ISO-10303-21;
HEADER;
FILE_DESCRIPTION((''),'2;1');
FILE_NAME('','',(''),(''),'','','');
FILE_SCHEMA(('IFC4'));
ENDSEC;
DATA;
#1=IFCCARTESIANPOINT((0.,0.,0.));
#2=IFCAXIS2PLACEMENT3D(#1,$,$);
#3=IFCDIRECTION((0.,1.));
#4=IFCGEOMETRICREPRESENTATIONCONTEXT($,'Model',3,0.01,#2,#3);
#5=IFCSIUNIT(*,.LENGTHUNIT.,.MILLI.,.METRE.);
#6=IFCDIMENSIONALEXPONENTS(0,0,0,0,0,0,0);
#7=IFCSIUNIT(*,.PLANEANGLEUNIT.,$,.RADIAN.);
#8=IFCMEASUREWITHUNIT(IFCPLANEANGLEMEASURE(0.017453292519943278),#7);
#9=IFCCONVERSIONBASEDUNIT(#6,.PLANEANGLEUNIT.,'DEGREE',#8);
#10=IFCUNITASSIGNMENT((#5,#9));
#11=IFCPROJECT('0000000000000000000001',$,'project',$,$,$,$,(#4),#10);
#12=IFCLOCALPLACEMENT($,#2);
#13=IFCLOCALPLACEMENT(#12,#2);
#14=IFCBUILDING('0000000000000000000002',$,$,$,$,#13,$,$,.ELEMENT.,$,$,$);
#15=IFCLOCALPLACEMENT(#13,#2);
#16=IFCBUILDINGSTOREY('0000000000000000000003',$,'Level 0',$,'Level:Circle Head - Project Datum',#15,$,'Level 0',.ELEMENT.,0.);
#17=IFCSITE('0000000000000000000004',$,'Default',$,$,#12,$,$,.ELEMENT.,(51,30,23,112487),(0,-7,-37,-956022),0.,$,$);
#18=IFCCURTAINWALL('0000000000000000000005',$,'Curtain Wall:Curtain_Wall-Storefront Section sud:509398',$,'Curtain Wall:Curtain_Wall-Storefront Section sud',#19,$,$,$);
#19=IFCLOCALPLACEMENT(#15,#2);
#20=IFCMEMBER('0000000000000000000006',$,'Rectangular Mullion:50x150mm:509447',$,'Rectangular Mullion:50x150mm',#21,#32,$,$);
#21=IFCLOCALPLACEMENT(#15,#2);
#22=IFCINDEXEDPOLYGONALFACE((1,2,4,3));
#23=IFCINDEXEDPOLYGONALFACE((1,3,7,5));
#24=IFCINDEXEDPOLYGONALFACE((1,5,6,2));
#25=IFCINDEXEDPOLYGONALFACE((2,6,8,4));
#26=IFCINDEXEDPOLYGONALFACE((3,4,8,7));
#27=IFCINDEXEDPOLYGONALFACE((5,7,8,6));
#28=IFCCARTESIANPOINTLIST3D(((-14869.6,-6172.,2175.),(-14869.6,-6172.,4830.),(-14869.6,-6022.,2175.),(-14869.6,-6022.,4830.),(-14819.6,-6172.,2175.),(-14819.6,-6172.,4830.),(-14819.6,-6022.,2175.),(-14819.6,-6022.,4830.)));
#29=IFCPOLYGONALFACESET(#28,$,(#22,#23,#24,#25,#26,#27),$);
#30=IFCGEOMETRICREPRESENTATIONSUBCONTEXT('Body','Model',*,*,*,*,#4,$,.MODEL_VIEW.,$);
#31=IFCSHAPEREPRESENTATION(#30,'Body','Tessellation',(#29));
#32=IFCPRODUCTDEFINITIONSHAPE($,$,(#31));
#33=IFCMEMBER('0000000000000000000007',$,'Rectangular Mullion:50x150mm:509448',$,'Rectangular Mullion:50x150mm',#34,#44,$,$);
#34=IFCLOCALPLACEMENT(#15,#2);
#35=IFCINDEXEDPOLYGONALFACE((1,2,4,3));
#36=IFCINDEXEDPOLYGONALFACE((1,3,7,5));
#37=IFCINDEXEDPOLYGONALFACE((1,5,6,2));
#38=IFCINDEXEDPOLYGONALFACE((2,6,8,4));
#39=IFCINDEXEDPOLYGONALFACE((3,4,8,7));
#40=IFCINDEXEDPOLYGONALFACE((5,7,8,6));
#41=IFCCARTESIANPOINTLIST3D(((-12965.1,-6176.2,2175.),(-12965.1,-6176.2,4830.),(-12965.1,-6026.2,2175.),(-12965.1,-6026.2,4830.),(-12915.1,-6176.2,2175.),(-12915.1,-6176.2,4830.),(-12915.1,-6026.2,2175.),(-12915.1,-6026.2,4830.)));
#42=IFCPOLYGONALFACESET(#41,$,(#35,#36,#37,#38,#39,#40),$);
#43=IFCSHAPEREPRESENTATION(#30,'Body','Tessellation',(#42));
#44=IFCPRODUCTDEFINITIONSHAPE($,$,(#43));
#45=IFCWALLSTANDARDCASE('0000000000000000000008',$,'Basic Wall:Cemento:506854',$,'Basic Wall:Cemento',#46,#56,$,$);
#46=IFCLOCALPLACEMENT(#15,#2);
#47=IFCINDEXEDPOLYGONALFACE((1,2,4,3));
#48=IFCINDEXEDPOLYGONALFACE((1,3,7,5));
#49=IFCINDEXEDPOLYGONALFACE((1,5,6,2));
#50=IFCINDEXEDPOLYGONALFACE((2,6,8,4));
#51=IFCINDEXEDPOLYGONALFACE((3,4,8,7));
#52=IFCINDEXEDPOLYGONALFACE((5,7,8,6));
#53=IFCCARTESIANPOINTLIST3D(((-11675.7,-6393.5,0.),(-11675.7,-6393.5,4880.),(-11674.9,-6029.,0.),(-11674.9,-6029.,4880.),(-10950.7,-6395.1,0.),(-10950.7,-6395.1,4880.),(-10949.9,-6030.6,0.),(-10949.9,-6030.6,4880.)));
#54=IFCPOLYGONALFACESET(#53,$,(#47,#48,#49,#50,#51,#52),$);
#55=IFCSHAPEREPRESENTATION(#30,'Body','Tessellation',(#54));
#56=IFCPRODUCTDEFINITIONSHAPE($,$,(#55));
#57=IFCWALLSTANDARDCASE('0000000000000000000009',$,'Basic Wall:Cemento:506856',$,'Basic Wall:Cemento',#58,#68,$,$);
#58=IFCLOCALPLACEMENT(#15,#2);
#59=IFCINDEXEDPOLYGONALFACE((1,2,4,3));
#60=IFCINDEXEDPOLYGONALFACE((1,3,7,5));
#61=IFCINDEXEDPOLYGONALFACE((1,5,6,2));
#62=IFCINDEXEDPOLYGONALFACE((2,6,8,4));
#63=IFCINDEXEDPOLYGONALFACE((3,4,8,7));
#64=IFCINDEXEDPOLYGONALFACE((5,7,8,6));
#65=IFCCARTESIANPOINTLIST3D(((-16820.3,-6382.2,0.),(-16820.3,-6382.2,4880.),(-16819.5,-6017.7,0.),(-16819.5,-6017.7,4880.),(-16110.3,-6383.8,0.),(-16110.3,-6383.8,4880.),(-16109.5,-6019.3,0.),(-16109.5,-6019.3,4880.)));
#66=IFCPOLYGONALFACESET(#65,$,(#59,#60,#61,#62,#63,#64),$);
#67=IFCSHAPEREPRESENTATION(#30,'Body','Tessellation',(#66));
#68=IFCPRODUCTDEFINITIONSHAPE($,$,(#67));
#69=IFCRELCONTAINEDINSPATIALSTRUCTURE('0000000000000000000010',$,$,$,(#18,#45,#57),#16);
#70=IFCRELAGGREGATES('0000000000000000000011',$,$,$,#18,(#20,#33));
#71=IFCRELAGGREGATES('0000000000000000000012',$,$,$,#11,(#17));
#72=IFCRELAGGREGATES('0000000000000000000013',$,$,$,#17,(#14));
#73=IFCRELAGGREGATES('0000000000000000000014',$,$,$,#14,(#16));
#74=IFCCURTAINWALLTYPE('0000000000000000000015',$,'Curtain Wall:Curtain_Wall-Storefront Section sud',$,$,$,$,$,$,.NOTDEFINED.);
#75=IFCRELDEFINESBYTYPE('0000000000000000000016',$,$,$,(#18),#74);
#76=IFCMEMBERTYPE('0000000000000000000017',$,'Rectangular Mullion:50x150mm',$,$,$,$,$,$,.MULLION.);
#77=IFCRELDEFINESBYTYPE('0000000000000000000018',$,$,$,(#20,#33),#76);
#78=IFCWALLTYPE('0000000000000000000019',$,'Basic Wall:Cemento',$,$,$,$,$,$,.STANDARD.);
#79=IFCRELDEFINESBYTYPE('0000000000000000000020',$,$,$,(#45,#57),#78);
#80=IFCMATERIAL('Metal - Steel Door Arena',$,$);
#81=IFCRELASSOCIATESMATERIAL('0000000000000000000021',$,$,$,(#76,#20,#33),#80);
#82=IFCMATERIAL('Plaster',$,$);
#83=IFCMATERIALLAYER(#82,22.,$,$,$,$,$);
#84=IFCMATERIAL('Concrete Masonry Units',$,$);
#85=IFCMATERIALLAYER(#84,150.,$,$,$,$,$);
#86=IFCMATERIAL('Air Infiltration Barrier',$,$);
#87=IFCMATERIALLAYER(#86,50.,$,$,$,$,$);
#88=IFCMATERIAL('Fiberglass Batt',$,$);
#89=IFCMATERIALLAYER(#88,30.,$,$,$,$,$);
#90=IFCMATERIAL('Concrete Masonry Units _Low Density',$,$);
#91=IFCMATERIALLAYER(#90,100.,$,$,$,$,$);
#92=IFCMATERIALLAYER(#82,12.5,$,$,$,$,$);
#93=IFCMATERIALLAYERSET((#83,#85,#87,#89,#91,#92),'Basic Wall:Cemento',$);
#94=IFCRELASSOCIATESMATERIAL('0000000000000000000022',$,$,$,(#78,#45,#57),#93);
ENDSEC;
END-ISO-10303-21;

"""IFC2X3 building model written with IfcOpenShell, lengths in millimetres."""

from ifc_helpers import new_model, entity, si_unit, converted_unit, direction, frame, frame_2d, origin, origin_2d_with_axis, place, context, subcontext, project, spatial, rectangle, extrude, source, transform, mapped, material, layer, layer_set, layer_usage, type_object, type_shapes, element, aggregate, save


model = new_model("IFC2X3")

# Units and contexts
model_context = context("Model", 3, precision=0.01, world=origin(), true_north=direction((0.0, 1.0)))
body_context = subcontext(model_context, "Body", "Model", "MODEL_VIEW")
ifc_project = project(units=[si_unit("LENGTHUNIT", "METRE", prefix="MILLI"), converted_unit("PLANEANGLEUNIT", "DEGREE", entity("IfcPlaneAngleMeasure", 0.017453292519943278), si_unit("PLANEANGLEUNIT", "RADIAN"), dimensions=[0, 0, 0, 0, 0, 0, 0])], contexts=[model_context])

# Site, building, storey
site_placement = place(None, origin())
site = spatial("IfcSite", under=ifc_project, at=site_placement, Name="Default", CompositionType="ELEMENT", RefLatitude=(51, 30, 23, 112487), RefLongitude=(0, -7, -37, -956022), RefElevation=0.0)
building_placement = place(site_placement, origin())
building = spatial("IfcBuilding", under=site, at=building_placement, CompositionType="ELEMENT")
storey_placement = place(building_placement, origin())
storey = spatial("IfcBuildingStorey", under=building, at=storey_placement, Name="Level 0", ObjectType="Level:Circle Head - Project Datum", LongName="Level 0", CompositionType="ELEMENT", Elevation=0.0)

# Curtain wall, members
curtain_wall_type = type_object("IfcCurtainWallType", Name="Curtain Wall:Curtain_Wall-Storefront Section sud", PredefinedType="NOTDEFINED")
curtain_wall_placement = place(storey_placement, origin())
curtain_wall = element("IfcCurtainWall", 1, at=curtain_wall_placement, inside=storey, type_object=curtain_wall_type, Name="Curtain Wall:Curtain_Wall-Storefront Section sud:509398", ObjectType="Curtain Wall:Curtain_Wall-Storefront Section sud")
ifc_material_1 = material(Name="Metal - Steel Door Arena")
member_type_1 = type_object("IfcMemberType", Name="Rectangular Mullion:50x150mm", PredefinedType="MULLION", material=ifc_material_1)
shared_shape_1 = source(origin(), body_context, "Body", "SweptSolid", [
    extrude(rectangle(XDim=50.0, YDim=150.0, at=origin_2d_with_axis()), frame((0.0, 0.0, -2655.0), z_axis=(0.0, 0.0, 1.0), x_axis=(-1.0, 0.0, 0.0)), (0.0, 0.0, 1.0), 2655.0),
])
type_shapes(member_type_1, [shared_shape_1])
member_1_placement = place(curtain_wall_placement, frame((-14844.6, -6097.0, 2175.0), z_axis=(0.0, 0.0, -1.0), x_axis=(1.0, 0.0, 0.0)))
member_1 = element("IfcMember", 2, at=member_1_placement, type_object=member_type_1, material=ifc_material_1, Name="Rectangular Mullion:50x150mm:509447", ObjectType="Rectangular Mullion:50x150mm", context=body_context, shape_type="MappedRepresentation", body=[
    mapped(shared_shape_1, transform((0.0, 0.0, 0.0), scale=1.0)),
])
member_2_placement = place(curtain_wall_placement, frame((-12940.1, -6101.2, 2175.0), z_axis=(0.0, 0.0, -1.0), x_axis=(1.0, 0.0, 0.0)))
member_2 = element("IfcMember", 3, at=member_2_placement, type_object=member_type_1, material=ifc_material_1, Name="Rectangular Mullion:50x150mm:509448", ObjectType="Rectangular Mullion:50x150mm", context=body_context, shape_type="MappedRepresentation", body=[
    mapped(shared_shape_1, transform((0.0, 0.0, 0.0), scale=1.0)),
])
aggregate(curtain_wall, [member_1, member_2])

# Shared definitions
ifc_material_2 = material(Name="Plaster")
ifc_layer_1 = layer(ifc_material_2, 22.0)
ifc_material_3 = material(Name="Concrete Masonry Units")
ifc_layer_2 = layer(ifc_material_3, 150.0)
ifc_material_4 = material(Name="Air Infiltration Barrier")
ifc_layer_3 = layer(ifc_material_4, 50.0)
ifc_material_5 = material(Name="Fiberglass Batt")
ifc_layer_4 = layer(ifc_material_5, 30.0)
ifc_material_6 = material(Name="Concrete Masonry Units _Low Density")
ifc_layer_5 = layer(ifc_material_6, 100.0)
ifc_layer_6 = layer(ifc_material_2, 12.5)
ifc_layer_set_1 = layer_set([ifc_layer_1, ifc_layer_2, ifc_layer_3, ifc_layer_4, ifc_layer_5, ifc_layer_6], Name="Basic Wall:Cemento")
ifc_layer_usage_1 = layer_usage(ifc_layer_set_1, "AXIS2", "NEGATIVE", 182.3)
wall_type_1 = type_object("IfcWallType", Name="Basic Wall:Cemento", PredefinedType="STANDARD", material=ifc_layer_set_1)

# Walls
wall_1_placement = place(storey_placement, frame((-10950.3, -6212.9, 0.0), z_axis=(0.0, 0.0, 1.0), x_axis=(-0.999998, 0.002199, 0.0)))
element("IfcWallStandardCase", 4, at=wall_1_placement, inside=storey, type_object=wall_type_1, material=ifc_layer_usage_1, Name="Basic Wall:Cemento:506854", ObjectType="Basic Wall:Cemento", context=body_context, shape_type="SweptSolid", body=[
    extrude(rectangle(XDim=725.0, YDim=364.5, at=frame_2d((362.5, 0.0), x_axis=(-1.0, 0.0))), origin(), (0.0, 0.0, 1.0), 4880.0),
])
wall_2_placement = place(storey_placement, frame((-16109.9, -6201.5, 0.0), z_axis=(0.0, 0.0, 1.0), x_axis=(-0.999998, 0.002199, 0.0)))
element("IfcWallStandardCase", 5, at=wall_2_placement, inside=storey, type_object=wall_type_1, material=ifc_layer_usage_1, Name="Basic Wall:Cemento:506856", ObjectType="Basic Wall:Cemento", context=body_context, shape_type="SweptSolid", body=[
    extrude(rectangle(XDim=710.0, YDim=364.5, at=frame_2d((355.0, 0.0), x_axis=(-1.0, 0.0))), origin(), (0.0, 0.0, 1.0), 4880.0),
])

save(model, "model.ifc")
